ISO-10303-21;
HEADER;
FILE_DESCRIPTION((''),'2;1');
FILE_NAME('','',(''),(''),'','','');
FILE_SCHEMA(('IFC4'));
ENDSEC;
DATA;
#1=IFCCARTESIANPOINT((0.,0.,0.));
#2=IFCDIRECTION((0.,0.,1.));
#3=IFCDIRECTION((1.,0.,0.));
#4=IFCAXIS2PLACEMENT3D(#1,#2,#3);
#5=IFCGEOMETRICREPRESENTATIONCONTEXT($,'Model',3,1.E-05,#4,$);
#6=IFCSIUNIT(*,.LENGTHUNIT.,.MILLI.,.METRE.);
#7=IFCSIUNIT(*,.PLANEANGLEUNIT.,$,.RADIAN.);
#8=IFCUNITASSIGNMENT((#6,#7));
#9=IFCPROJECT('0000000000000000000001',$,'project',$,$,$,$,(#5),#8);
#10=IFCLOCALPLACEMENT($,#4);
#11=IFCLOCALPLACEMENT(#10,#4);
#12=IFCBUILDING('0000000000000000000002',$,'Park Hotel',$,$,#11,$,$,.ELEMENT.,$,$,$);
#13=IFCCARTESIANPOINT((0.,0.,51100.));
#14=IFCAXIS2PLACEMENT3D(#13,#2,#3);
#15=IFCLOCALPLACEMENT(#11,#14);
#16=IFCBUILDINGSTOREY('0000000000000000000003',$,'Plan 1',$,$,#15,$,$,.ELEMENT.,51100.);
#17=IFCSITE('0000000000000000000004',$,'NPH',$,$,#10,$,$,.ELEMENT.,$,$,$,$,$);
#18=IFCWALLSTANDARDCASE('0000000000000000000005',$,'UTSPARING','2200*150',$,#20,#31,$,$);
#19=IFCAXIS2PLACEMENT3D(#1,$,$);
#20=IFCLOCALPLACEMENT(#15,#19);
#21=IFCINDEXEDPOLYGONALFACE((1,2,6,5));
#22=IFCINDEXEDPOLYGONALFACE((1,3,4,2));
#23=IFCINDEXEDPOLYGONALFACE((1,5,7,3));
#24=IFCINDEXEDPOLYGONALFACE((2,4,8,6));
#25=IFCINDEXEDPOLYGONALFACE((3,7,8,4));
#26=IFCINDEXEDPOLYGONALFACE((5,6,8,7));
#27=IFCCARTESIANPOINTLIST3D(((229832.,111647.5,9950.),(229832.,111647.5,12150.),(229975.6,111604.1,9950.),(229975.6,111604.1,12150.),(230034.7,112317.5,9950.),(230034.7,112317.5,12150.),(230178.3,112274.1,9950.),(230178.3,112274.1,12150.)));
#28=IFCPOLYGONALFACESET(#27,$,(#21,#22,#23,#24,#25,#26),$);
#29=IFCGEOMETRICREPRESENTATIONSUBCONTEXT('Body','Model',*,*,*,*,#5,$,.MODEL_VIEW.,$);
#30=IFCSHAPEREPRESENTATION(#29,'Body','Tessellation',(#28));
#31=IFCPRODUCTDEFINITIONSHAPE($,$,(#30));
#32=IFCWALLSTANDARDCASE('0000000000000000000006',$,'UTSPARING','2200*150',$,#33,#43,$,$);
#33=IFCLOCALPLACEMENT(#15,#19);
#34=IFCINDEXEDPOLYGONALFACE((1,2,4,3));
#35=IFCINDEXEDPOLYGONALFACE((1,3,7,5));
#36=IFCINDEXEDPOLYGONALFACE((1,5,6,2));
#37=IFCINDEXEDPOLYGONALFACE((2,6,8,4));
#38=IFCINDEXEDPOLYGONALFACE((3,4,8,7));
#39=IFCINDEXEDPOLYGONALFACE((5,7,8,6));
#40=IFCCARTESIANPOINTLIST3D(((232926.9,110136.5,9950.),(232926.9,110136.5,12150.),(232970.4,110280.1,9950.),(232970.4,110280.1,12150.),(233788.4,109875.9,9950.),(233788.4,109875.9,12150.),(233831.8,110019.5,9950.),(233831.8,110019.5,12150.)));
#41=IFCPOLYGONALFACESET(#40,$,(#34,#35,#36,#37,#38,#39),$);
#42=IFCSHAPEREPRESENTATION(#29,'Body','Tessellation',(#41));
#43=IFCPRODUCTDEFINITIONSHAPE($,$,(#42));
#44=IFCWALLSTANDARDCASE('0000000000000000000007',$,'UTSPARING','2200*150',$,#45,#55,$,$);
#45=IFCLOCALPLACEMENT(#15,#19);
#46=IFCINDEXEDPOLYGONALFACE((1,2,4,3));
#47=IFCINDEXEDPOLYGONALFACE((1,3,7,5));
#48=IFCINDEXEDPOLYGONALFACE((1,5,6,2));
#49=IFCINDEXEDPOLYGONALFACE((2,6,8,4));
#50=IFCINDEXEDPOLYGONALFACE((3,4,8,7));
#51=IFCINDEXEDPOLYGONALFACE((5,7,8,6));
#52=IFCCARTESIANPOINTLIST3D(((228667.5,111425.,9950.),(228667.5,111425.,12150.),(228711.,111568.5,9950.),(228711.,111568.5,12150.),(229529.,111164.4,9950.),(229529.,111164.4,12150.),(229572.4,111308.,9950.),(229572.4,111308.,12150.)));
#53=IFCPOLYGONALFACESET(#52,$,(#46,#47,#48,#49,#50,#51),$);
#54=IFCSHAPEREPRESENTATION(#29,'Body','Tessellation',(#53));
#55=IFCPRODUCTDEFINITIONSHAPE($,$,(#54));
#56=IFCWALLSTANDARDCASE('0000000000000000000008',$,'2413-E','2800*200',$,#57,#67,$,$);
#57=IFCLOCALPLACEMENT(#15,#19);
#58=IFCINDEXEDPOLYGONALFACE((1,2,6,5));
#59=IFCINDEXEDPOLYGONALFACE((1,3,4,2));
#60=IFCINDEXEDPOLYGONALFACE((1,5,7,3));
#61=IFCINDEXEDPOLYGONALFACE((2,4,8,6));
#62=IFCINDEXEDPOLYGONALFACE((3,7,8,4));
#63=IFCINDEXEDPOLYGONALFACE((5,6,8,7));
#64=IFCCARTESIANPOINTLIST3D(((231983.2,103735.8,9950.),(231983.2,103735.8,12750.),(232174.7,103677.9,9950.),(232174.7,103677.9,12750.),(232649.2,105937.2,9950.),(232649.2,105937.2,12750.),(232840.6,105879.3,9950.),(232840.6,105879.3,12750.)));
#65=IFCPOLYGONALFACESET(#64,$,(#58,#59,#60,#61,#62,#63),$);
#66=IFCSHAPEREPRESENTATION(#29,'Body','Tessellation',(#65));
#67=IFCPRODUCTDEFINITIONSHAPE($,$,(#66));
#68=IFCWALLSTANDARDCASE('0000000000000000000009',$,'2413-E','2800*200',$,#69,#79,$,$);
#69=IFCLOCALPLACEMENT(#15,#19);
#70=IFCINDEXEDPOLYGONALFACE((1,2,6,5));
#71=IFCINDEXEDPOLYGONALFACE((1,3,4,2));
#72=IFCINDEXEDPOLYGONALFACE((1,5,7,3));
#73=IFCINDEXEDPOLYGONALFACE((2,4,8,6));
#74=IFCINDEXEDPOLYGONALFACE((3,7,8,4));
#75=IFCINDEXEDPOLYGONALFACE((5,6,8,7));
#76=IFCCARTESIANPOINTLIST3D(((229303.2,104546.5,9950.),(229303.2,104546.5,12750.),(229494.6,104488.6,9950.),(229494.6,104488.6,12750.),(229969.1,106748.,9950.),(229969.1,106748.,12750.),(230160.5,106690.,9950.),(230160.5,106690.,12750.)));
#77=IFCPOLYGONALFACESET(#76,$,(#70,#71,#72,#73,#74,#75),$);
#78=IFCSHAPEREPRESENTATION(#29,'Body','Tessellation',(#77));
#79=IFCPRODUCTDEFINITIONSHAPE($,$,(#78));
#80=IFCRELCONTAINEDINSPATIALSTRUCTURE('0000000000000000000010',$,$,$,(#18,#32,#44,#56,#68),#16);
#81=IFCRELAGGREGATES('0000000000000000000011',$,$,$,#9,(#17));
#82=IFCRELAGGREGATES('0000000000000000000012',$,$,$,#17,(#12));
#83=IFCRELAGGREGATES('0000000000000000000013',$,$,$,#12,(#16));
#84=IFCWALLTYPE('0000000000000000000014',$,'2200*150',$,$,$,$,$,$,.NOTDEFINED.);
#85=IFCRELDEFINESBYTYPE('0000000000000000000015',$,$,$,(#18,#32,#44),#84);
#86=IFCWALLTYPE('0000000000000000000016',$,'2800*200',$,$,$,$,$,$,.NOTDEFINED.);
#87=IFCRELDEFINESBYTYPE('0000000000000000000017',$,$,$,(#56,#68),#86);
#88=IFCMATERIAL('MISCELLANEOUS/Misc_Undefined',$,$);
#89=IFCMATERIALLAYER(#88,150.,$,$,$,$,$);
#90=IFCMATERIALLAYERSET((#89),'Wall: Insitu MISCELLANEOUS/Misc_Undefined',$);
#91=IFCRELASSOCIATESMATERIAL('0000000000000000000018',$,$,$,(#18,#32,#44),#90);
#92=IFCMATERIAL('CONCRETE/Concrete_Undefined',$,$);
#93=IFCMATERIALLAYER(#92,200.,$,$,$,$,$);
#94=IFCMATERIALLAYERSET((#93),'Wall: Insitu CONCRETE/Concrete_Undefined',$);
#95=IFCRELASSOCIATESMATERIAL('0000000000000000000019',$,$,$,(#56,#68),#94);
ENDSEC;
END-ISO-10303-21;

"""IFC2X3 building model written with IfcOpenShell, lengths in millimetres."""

from ifc_helpers import new_model, si_unit, frame, frame_2d, origin_with_axes, place, context, subcontext, project, spatial, rectangle, extrude, material, layer, layer_set, layer_usage, type_object, element, save


model = new_model("IFC2X3")

# Units and contexts
model_context = context("Model", 3, precision=1e-05, world=origin_with_axes())
body_context = subcontext(model_context, "Body", "Model", "MODEL_VIEW")
ifc_project = project(units=[si_unit("LENGTHUNIT", "METRE", prefix="MILLI"), si_unit("PLANEANGLEUNIT", "RADIAN")], contexts=[model_context])

# Site, building, storey
site_placement = place(None, origin_with_axes())
site = spatial("IfcSite", under=ifc_project, at=site_placement, Name="NPH", CompositionType="ELEMENT")
building_placement = place(site_placement, origin_with_axes())
building = spatial("IfcBuilding", under=site, at=building_placement, Name="Park Hotel", CompositionType="ELEMENT")
storey_placement = place(building_placement, frame((0.0, 0.0, 51100.0), z_axis=(0.0, 0.0, 1.0), x_axis=(1.0, 0.0, 0.0)))
storey = spatial("IfcBuildingStorey", under=building, at=storey_placement, Name="Plan 1", CompositionType="ELEMENT", Elevation=51100.0)

# Walls
ifc_material_1 = material(Name="MISCELLANEOUS/Misc_Undefined")
ifc_layer_1 = layer(ifc_material_1, 150.0)
ifc_layer_set_1 = layer_set([ifc_layer_1], Name="Wall: Insitu MISCELLANEOUS/Misc_Undefined")
wall_type_1 = type_object("IfcWallType", Name="2200*150", PredefinedType="NOTDEFINED")
ifc_layer_usage_1 = layer_usage(ifc_layer_set_1, "AXIS2", "POSITIVE", -75.0)
wall_1_placement = place(storey_placement, frame((229903.8, 111625.8, 9950.0), z_axis=(0.0, 0.0, 1.0), x_axis=(0.289542, 0.957165, 0.0)))
element("IfcWallStandardCase", 1, at=wall_1_placement, inside=storey, type_object=wall_type_1, material=ifc_layer_usage_1, Name="UTSPARING", Description="2200*150", context=body_context, shape_type="SweptSolid", body=[
    extrude(rectangle(XDim=700.0, YDim=150.0, at=frame_2d((0.0, 350.0), x_axis=(0.0, -1.0))), frame((0.0, 0.0, 0.0), z_axis=(0.0, 0.0, 1.0), x_axis=(0.0, -1.0, 0.0)), (0.0, 0.0, 1.0), 2200.0),
])
ifc_layer_usage_2 = layer_usage(ifc_layer_set_1, "AXIS2", "POSITIVE", -75.0)
wall_2_placement = place(storey_placement, frame((232948.6, 110208.3, 9950.0), z_axis=(0.0, 0.0, 1.0), x_axis=(0.957166, -0.289541, 0.0)))
element("IfcWallStandardCase", 2, at=wall_2_placement, inside=storey, type_object=wall_type_1, material=ifc_layer_usage_2, Name="UTSPARING", Description="2200*150", context=body_context, shape_type="SweptSolid", body=[
    extrude(rectangle(XDim=900.0, YDim=150.0, at=frame_2d((0.0, 450.0), x_axis=(0.0, -1.0))), frame((0.0, 0.0, 0.0), z_axis=(0.0, 0.0, 1.0), x_axis=(0.0, -1.0, 0.0)), (0.0, 0.0, 1.0), 2200.0),
])
ifc_layer_usage_3 = layer_usage(ifc_layer_set_1, "AXIS2", "POSITIVE", -75.0)
wall_3_placement = place(storey_placement, frame((228689.3, 111496.8, 9950.0), z_axis=(0.0, 0.0, 1.0), x_axis=(0.957166, -0.289541, 0.0)))
element("IfcWallStandardCase", 3, at=wall_3_placement, inside=storey, type_object=wall_type_1, material=ifc_layer_usage_3, Name="UTSPARING", Description="2200*150", context=body_context, shape_type="SweptSolid", body=[
    extrude(rectangle(XDim=900.0, YDim=150.0, at=frame_2d((0.0, 450.0), x_axis=(0.0, -1.0))), frame((0.0, 0.0, 0.0), z_axis=(0.0, 0.0, 1.0), x_axis=(0.0, -1.0, 0.0)), (0.0, 0.0, 1.0), 2200.0),
])
ifc_material_2 = material(Name="CONCRETE/Concrete_Undefined")
ifc_layer_2 = layer(ifc_material_2, 200.0)
ifc_layer_set_2 = layer_set([ifc_layer_2], Name="Wall: Insitu CONCRETE/Concrete_Undefined")
ifc_layer_usage_4 = layer_usage(ifc_layer_set_2, "AXIS2", "POSITIVE", -100.0)
wall_type_2 = type_object("IfcWallType", Name="2800*200", PredefinedType="NOTDEFINED")
wall_4_placement = place(storey_placement, frame((232079.0, 103706.8, 9950.0), z_axis=(0.0, 0.0, 1.0), x_axis=(0.289536, 0.957167, 0.0)))
element("IfcWallStandardCase", 4, at=wall_4_placement, inside=storey, type_object=wall_type_2, material=ifc_layer_usage_4, Name="2413-E", Description="2800*200", context=body_context, shape_type="SweptSolid", body=[
    extrude(rectangle(XDim=2300.0, YDim=200.0, at=frame_2d((0.0, 1150.0), x_axis=(0.0, -1.0))), frame((0.0, 0.0, 0.0), z_axis=(0.0, 0.0, 1.0), x_axis=(0.0, -1.0, 0.0)), (0.0, 0.0, 1.0), 2800.0),
])
ifc_layer_usage_5 = layer_usage(ifc_layer_set_2, "AXIS2", "POSITIVE", -100.0)
wall_5_placement = place(storey_placement, frame((229398.9, 104517.5, 9950.0), z_axis=(0.0, 0.0, 1.0), x_axis=(0.289536, 0.957167, 0.0)))
element("IfcWallStandardCase", 5, at=wall_5_placement, inside=storey, type_object=wall_type_2, material=ifc_layer_usage_5, Name="2413-E", Description="2800*200", context=body_context, shape_type="SweptSolid", body=[
    extrude(rectangle(XDim=2300.0, YDim=200.0, at=frame_2d((0.0, 1150.0), x_axis=(0.0, -1.0))), frame((0.0, 0.0, 0.0), z_axis=(0.0, 0.0, 1.0), x_axis=(0.0, -1.0, 0.0)), (0.0, 0.0, 1.0), 2800.0),
])

save(model, "model.ifc")
